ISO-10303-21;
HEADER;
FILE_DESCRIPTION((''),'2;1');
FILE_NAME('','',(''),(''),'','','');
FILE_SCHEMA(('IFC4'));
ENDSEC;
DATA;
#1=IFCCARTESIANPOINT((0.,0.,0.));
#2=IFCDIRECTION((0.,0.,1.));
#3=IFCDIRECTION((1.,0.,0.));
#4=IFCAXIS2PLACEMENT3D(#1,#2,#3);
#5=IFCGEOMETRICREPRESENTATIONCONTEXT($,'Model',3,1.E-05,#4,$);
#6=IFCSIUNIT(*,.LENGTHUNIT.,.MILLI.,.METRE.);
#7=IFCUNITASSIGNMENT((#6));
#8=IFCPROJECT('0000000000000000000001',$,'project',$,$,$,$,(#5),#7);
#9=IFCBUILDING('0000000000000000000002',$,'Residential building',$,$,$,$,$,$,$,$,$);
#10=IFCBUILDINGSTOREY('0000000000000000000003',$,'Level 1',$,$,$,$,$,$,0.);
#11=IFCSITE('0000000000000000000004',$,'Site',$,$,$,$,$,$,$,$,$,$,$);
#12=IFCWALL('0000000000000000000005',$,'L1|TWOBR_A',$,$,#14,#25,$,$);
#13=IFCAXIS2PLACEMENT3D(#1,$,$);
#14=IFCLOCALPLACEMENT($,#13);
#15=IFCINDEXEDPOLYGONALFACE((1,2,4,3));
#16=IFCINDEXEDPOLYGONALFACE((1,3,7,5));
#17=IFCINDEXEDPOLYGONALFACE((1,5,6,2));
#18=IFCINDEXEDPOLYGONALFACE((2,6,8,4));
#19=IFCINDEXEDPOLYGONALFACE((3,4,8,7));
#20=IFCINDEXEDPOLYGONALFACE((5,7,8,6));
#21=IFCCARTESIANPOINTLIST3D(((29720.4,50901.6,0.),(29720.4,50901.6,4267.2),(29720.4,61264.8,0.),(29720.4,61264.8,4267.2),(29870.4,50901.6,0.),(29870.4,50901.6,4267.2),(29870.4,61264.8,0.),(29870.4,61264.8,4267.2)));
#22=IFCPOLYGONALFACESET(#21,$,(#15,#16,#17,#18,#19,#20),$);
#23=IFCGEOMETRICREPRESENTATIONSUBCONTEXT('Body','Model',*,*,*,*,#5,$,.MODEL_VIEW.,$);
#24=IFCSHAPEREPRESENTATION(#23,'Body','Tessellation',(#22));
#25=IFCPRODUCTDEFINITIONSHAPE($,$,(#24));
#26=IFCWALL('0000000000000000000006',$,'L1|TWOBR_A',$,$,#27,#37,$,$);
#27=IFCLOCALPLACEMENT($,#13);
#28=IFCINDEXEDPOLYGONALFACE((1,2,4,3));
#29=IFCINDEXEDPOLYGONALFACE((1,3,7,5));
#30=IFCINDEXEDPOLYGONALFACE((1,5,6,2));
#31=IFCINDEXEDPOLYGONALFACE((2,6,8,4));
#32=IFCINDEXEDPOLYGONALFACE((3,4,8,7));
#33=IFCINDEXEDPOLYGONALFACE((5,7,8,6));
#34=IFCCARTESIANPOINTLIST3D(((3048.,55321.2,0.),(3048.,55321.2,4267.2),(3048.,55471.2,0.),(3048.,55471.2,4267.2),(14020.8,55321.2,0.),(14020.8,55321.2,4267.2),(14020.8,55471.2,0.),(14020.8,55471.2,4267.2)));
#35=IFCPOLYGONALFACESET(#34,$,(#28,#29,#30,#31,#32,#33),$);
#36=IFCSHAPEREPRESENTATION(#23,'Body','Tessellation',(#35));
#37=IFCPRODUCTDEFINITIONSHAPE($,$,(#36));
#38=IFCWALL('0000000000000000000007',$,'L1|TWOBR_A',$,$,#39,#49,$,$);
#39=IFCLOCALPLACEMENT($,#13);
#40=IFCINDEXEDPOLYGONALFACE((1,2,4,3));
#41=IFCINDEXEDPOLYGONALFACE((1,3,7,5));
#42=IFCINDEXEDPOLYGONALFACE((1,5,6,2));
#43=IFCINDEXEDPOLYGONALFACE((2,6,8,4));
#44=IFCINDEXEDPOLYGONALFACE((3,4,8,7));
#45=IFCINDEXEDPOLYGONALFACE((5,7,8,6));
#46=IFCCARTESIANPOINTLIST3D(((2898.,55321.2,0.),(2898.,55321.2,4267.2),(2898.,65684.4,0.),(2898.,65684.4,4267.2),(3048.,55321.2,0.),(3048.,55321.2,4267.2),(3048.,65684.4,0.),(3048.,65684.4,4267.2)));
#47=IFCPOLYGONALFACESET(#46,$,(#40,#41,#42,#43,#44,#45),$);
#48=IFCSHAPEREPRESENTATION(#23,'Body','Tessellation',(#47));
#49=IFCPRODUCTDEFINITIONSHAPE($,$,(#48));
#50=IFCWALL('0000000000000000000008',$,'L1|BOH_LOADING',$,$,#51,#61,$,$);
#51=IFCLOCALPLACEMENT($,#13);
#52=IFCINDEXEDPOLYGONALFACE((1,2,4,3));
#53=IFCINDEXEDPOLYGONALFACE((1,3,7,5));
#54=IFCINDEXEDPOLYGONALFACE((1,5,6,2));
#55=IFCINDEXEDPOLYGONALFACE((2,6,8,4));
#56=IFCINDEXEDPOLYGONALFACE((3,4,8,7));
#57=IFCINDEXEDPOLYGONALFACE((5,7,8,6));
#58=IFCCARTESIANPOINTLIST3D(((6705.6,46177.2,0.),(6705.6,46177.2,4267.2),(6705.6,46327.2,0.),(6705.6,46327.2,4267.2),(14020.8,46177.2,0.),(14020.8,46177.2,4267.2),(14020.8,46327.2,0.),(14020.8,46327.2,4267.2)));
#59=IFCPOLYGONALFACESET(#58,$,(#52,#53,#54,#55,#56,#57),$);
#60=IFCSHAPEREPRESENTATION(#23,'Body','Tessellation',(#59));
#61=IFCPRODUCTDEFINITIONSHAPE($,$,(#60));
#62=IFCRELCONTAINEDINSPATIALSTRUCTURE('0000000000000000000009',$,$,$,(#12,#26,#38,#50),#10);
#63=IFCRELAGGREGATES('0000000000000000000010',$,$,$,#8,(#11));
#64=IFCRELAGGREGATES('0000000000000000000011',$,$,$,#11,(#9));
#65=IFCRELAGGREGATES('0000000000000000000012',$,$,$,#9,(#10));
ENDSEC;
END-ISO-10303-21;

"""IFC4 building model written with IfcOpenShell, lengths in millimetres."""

from ifc_helpers import new_model, si_unit, frame, origin_with_axes, place, context, subcontext, project, spatial, indexed_curve, outline, extrude, element, save


model = new_model("IFC4")

# Units and contexts
model_context = context("Model", 3, precision=1e-05, world=origin_with_axes())
body_context = subcontext(model_context, "Body", "Model", "MODEL_VIEW")
ifc_project = project(units=[si_unit("LENGTHUNIT", "METRE", prefix="MILLI")], contexts=[model_context])

# Site, building, storey
site = spatial("IfcSite", under=ifc_project, Name="Site")
building = spatial("IfcBuilding", under=site, Name="Residential building")
storey = spatial("IfcBuildingStorey", under=building, Name="Level 1", Elevation=0.0)

# Walls
wall_1_placement = place(None, frame((29870.4, 50901.6, 0.0), z_axis=(0.0, 0.0, 1.0), x_axis=(0.0, 1.0, 0.0)))
element("IfcWall", 1, at=wall_1_placement, inside=storey, Name="L1|TWOBR_A", context=body_context, shape_type="SweptSolid", body=[
    extrude(outline(indexed_curve([(0.0, 0.0), (0.0, 150.0), (10363.2, 150.0), (10363.2, 0.0), (0.0, 0.0)], self_intersect=False)), origin_with_axes(), (0.0, 0.0, 1.0), 4267.2),
])
wall_2_placement = place(None, frame((3048.0, 55321.2, 0.0), z_axis=(0.0, 0.0, 1.0), x_axis=(1.0, 0.0, 0.0)))
element("IfcWall", 2, at=wall_2_placement, inside=storey, Name="L1|TWOBR_A", context=body_context, shape_type="SweptSolid", body=[
    extrude(outline(indexed_curve([(0.0, 0.0), (0.0, 150.0), (10972.8, 150.0), (10972.8, 0.0), (0.0, 0.0)], self_intersect=False)), origin_with_axes(), (0.0, 0.0, 1.0), 4267.2),
])
wall_3_placement = place(None, frame((3048.0, 55321.2, 0.0), z_axis=(0.0, 0.0, 1.0), x_axis=(0.0, 1.0, 0.0)))
element("IfcWall", 3, at=wall_3_placement, inside=storey, Name="L1|TWOBR_A", context=body_context, shape_type="SweptSolid", body=[
    extrude(outline(indexed_curve([(0.0, 0.0), (0.0, 150.0), (10363.2, 150.0), (10363.2, 0.0), (0.0, 0.0)], self_intersect=False)), origin_with_axes(), (0.0, 0.0, 1.0), 4267.2),
])
wall_4_placement = place(None, frame((6705.6, 46177.2, 0.0), z_axis=(0.0, 0.0, 1.0), x_axis=(1.0, 0.0, 0.0)))
element("IfcWall", 4, at=wall_4_placement, inside=storey, Name="L1|BOH_LOADING", context=body_context, shape_type="SweptSolid", body=[
    extrude(outline(indexed_curve([(0.0, 0.0), (0.0, 150.0), (7315.2, 150.0), (7315.2, 0.0), (0.0, 0.0)], self_intersect=False)), origin_with_axes(), (0.0, 0.0, 1.0), 4267.2),
])

save(model, "model.ifc")
